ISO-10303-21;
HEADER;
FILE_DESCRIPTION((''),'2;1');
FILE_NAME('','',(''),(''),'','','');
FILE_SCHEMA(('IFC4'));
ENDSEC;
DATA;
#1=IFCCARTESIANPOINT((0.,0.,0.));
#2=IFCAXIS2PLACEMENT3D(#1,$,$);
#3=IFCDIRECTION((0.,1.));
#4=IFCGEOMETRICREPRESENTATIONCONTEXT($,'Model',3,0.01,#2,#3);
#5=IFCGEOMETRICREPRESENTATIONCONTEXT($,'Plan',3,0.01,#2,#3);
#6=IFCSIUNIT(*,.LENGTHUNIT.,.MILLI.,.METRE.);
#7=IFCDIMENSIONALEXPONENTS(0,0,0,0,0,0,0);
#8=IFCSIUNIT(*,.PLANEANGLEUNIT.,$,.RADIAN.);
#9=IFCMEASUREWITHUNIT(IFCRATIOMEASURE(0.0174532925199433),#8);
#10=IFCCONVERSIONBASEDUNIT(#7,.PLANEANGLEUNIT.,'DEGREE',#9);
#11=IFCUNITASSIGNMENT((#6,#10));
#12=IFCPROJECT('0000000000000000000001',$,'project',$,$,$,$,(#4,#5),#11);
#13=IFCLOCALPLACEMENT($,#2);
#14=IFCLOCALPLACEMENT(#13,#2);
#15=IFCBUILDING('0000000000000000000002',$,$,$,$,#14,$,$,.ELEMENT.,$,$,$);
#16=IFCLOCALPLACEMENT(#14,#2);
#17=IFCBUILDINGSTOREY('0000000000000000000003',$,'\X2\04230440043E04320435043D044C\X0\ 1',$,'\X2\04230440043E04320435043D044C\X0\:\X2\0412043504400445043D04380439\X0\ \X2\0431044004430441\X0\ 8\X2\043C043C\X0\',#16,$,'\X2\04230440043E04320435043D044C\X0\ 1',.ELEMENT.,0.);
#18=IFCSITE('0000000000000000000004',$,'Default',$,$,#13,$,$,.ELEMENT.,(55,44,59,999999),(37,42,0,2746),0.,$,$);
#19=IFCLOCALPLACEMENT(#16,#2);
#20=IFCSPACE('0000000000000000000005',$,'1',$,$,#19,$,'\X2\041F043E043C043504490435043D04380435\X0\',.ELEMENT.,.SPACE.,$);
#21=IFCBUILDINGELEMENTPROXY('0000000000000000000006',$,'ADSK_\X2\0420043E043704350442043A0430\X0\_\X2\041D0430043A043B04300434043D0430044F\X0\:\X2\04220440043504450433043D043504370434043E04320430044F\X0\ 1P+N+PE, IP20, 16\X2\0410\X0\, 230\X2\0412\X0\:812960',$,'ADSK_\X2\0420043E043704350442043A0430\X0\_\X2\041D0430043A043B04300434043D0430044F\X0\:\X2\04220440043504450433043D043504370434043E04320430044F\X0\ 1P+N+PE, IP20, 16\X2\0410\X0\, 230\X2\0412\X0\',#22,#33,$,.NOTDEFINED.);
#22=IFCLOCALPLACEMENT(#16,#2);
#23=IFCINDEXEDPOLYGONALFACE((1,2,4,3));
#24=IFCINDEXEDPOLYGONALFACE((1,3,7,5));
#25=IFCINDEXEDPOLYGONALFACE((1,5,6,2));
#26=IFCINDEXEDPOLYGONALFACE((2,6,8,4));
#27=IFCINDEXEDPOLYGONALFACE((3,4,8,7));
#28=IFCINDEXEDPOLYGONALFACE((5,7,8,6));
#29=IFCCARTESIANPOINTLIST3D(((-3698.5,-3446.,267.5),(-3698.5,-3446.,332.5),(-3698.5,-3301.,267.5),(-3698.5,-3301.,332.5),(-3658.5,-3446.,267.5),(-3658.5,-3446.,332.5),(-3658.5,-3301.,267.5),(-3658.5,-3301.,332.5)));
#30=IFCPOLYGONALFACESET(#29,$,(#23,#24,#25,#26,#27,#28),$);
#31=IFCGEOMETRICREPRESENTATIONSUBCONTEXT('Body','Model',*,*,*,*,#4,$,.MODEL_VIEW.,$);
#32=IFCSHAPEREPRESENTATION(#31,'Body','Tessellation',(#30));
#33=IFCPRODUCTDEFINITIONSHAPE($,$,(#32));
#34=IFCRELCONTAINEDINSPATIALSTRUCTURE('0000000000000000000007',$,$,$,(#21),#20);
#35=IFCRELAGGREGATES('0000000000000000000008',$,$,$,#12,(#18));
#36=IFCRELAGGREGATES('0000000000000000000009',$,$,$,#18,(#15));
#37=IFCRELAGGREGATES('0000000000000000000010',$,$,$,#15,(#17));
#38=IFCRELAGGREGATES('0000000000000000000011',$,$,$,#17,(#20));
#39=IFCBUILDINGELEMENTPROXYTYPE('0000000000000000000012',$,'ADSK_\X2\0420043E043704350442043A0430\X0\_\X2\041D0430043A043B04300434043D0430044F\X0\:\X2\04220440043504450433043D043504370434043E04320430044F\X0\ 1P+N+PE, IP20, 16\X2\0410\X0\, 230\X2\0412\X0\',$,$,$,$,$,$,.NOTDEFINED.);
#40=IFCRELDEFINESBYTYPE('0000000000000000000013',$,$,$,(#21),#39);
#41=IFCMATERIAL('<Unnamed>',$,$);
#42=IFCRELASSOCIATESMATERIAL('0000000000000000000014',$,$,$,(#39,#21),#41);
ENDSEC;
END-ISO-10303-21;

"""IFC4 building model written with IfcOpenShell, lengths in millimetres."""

from ifc_helpers import new_model, entity, si_unit, converted_unit, direction, frame, origin, origin_2d_with_axis, place, context, subcontext, project, spatial, rectangle, extrude, source, transform, mapped, material, type_object, type_shapes, element, save


model = new_model("IFC4")

# Units and contexts
model_context = context("Model", 3, precision=0.01, world=origin(), true_north=direction((0.0, 1.0)))
plan_context = context("Plan", 3, precision=0.01, world=origin(), true_north=direction((0.0, 1.0)))
body_context = subcontext(model_context, "Body", "Model", "MODEL_VIEW")
ifc_project = project(units=[si_unit("LENGTHUNIT", "METRE", prefix="MILLI"), converted_unit("PLANEANGLEUNIT", "DEGREE", entity("IfcRatioMeasure", 0.0174532925199433), si_unit("PLANEANGLEUNIT", "RADIAN"), dimensions=[0, 0, 0, 0, 0, 0, 0])], contexts=[model_context, plan_context])

# Site, building, storey
site_placement = place(None, origin())
site = spatial("IfcSite", under=ifc_project, at=site_placement, Name="Default", CompositionType="ELEMENT", RefLatitude=(55, 44, 59, 999999), RefLongitude=(37, 42, 0, 2746), RefElevation=0.0)
building_placement = place(site_placement, origin())
building = spatial("IfcBuilding", under=site, at=building_placement, CompositionType="ELEMENT")
storey_placement = place(building_placement, origin())
storey = spatial("IfcBuildingStorey", under=building, at=storey_placement, Name="Уровень 1", ObjectType="Уровень:Верхний брус 8мм", LongName="Уровень 1", CompositionType="ELEMENT", Elevation=0.0)

# Shared definitions
space_placement = place(storey_placement, origin())
space = spatial("IfcSpace", under=storey, at=space_placement, Name="1", LongName="Помещение", CompositionType="ELEMENT", PredefinedType="SPACE")

# Building element proxy
ifc_material_1 = material(Name="<Unnamed>")
building_element_proxy_type = type_object("IfcBuildingElementProxyType", Name="ADSK_Розетка_Накладная:Трехгнездовая 1P+N+PE, IP20, 16А, 230В", PredefinedType="NOTDEFINED", material=ifc_material_1)
shared_shape = source(origin(), body_context, "Body", "SweptSolid", [
    extrude(rectangle(XDim=145.0, YDim=40.0, at=origin_2d_with_axis()), frame((0.0, 20.0, -32.5), z_axis=(0.0, 0.0, 1.0), x_axis=(-1.0, 0.0, 0.0)), (0.0, 0.0, 1.0), 65.0),
])
type_shapes(building_element_proxy_type, [shared_shape])
proxy_placement = place(space_placement, frame((-3698.5, -3373.5, 300.0), z_axis=(0.0, 0.0, 1.0), x_axis=(0.0, -1.0, 0.0)))
element("IfcBuildingElementProxy", 1, at=proxy_placement, inside=space, type_object=building_element_proxy_type, material=ifc_material_1, Name="ADSK_Розетка_Накладная:Трехгнездовая 1P+N+PE, IP20, 16А, 230В:812960", ObjectType="ADSK_Розетка_Накладная:Трехгнездовая 1P+N+PE, IP20, 16А, 230В", PredefinedType="NOTDEFINED", context=body_context, shape_type="MappedRepresentation", body=[
    mapped(shared_shape, transform((0.0, 0.0, 0.0), scale=1.0)),
])

save(model, "model.ifc")
